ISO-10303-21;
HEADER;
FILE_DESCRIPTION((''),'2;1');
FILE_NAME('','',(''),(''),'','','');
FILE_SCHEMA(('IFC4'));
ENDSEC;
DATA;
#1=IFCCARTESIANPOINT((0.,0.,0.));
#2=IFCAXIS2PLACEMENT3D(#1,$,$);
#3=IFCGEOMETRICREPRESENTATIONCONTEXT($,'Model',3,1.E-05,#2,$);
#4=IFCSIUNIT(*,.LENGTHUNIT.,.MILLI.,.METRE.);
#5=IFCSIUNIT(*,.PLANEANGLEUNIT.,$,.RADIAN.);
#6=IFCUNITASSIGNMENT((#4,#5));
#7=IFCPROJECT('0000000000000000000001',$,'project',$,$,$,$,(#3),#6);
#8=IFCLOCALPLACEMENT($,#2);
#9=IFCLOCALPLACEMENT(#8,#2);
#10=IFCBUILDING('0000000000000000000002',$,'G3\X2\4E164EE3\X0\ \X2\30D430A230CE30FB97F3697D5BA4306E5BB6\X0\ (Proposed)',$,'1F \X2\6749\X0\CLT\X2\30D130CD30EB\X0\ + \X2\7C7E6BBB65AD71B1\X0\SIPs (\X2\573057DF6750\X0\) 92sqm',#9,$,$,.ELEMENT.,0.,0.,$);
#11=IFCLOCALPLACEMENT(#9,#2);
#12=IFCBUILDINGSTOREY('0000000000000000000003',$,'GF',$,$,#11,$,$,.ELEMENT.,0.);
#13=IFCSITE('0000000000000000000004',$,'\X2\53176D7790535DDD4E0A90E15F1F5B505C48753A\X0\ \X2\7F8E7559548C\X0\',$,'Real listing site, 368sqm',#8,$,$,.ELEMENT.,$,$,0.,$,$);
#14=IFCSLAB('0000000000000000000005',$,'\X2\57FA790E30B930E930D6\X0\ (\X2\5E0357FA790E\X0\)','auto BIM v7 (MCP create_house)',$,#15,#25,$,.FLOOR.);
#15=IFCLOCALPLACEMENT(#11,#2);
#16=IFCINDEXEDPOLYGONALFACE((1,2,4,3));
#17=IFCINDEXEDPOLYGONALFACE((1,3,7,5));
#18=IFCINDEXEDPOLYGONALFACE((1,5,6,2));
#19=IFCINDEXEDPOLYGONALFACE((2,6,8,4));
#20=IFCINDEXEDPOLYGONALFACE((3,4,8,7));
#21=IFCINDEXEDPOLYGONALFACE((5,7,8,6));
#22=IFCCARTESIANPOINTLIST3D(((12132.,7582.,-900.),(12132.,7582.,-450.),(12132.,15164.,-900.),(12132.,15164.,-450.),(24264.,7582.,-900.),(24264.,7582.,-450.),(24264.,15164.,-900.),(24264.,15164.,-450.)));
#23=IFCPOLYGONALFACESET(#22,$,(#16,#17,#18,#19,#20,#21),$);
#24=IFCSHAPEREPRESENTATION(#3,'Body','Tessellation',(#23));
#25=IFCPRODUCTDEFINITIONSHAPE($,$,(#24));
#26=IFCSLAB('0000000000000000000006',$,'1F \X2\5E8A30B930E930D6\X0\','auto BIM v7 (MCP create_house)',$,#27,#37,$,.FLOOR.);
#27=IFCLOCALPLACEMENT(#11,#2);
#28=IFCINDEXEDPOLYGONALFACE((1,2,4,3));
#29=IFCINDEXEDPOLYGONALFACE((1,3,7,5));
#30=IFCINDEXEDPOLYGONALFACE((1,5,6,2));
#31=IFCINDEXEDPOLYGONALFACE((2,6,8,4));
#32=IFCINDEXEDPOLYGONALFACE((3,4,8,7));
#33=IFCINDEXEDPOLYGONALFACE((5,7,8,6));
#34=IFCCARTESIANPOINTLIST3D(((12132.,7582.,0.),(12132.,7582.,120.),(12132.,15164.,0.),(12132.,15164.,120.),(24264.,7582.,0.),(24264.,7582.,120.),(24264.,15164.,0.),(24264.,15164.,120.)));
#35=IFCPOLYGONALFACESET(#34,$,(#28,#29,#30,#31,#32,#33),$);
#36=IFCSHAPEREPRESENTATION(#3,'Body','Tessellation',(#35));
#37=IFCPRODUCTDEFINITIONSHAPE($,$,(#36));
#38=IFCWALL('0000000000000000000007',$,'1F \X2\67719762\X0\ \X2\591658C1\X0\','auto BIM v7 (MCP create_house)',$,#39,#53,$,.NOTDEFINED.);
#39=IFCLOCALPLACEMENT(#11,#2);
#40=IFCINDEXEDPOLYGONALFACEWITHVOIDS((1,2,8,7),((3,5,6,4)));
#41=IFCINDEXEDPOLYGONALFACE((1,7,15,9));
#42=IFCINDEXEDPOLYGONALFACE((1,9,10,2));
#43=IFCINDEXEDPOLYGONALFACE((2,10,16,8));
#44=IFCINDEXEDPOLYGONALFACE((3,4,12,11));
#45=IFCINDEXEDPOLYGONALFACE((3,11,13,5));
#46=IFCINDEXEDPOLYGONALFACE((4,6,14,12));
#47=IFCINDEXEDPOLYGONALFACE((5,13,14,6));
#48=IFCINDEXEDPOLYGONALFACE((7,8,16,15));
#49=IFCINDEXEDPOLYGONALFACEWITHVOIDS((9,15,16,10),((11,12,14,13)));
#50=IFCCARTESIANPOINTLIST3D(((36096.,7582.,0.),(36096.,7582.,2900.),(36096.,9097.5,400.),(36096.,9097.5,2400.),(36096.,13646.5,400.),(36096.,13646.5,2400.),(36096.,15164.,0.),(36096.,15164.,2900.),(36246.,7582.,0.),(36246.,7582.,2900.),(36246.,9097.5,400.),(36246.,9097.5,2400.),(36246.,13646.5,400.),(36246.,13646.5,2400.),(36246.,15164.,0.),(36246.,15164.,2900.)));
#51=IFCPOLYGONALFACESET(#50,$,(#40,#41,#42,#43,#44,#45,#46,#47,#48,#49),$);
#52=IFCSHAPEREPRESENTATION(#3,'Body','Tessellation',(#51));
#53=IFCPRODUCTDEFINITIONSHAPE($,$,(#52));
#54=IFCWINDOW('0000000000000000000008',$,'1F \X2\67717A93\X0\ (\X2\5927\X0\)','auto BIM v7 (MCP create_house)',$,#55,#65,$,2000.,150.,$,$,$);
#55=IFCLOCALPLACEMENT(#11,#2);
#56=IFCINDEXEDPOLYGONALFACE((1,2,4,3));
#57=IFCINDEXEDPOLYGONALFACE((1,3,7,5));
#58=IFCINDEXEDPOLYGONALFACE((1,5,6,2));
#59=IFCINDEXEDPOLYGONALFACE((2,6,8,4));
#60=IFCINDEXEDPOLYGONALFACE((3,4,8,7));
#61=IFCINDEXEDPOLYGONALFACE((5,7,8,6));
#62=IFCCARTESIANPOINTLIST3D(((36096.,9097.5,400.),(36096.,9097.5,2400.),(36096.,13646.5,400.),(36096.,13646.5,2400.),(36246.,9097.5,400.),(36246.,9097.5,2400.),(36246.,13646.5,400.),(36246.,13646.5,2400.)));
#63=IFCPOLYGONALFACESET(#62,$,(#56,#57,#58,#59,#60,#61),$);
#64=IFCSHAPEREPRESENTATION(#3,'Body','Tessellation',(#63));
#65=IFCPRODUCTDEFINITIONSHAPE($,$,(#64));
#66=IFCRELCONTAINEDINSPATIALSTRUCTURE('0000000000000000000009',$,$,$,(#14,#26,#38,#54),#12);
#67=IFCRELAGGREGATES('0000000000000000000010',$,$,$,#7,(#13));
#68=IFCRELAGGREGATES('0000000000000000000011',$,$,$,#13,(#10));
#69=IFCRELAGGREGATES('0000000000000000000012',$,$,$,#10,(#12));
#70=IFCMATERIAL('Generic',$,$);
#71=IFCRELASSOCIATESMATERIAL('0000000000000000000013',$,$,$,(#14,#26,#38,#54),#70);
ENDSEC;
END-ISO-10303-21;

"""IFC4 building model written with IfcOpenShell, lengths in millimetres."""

from ifc_helpers import new_model, si_unit, frame, frame_2d, origin, place, context, project, spatial, rectangle, extrude, material, element, fill, save


model = new_model("IFC4")

# Units and contexts
model_context = context("Model", 3, precision=1e-05, world=origin())
ifc_project = project(units=[si_unit("LENGTHUNIT", "METRE", prefix="MILLI"), si_unit("PLANEANGLEUNIT", "RADIAN")], contexts=[model_context])

# Site, building, storey
site_placement = place(None, origin())
site = spatial("IfcSite", under=ifc_project, at=site_placement, Name="北海道川上郡弟子屈町 美留和", ObjectType="Real listing site, 368sqm", CompositionType="ELEMENT", RefElevation=0.0)
building_placement = place(site_placement, origin())
building = spatial("IfcBuilding", under=site, at=building_placement, Name="G3世代 ピアノ・音楽室の家 (Proposed)", ObjectType="1F 杉CLTパネル + 籾殻断熱SIPs (地域材) 92sqm", CompositionType="ELEMENT", ElevationOfRefHeight=0.0, ElevationOfTerrain=0.0)
storey_placement = place(building_placement, origin())
storey = spatial("IfcBuildingStorey", under=building, at=storey_placement, Name="GF", CompositionType="ELEMENT", Elevation=0.0)

# Slabs
ifc_material = material(Name="Generic")
slab_1_placement = place(storey_placement, frame((6066.0, 3791.0, -450.0)))
element("IfcSlab", 1, at=slab_1_placement, inside=storey, material=ifc_material, Name="基礎スラブ (布基礎)", Description="auto BIM v7 (MCP create_house)", PredefinedType="FLOOR", context=model_context, shape_type="SweptSolid", body=[
    extrude(rectangle(XDim=12132.0, YDim=7582.0, at=frame_2d((6066.0, 3791.0))), frame((6066.0, 3791.0, -450.0)), (0.0, 0.0, 1.0), 450.0),
])
slab_2_placement = place(storey_placement, frame((6066.0, 3791.0, 0.0)))
element("IfcSlab", 2, at=slab_2_placement, inside=storey, material=ifc_material, Name="1F 床スラブ", Description="auto BIM v7 (MCP create_house)", PredefinedType="FLOOR", context=model_context, shape_type="SweptSolid", body=[
    extrude(rectangle(XDim=12132.0, YDim=7582.0, at=frame_2d((6066.0, 3791.0))), frame((6066.0, 3791.0, 0.0)), (0.0, 0.0, 1.0), 120.0),
])

# Wall, opening, window
wall_1_placement = place(storey_placement, frame((18048.0, 3791.0, 0.0)))
wall_1 = element("IfcWall", 3, at=wall_1_placement, inside=storey, material=ifc_material, Name="1F 東面 外壁", Description="auto BIM v7 (MCP create_house)", PredefinedType="NOTDEFINED", context=model_context, shape_type="SweptSolid", body=[
    extrude(rectangle(XDim=150.0, YDim=7582.0, at=frame_2d((75.0, 3791.0))), frame((18048.0, 3791.0, 0.0)), (0.0, 0.0, 1.0), 2900.0),
])
opening_1_placement = place(storey_placement, frame((18048.0, 4549.0, 200.0)))
opening_1 = element("IfcOpeningElement", 4, at=opening_1_placement, cuts=wall_1, PredefinedType="NOTDEFINED", context=model_context, shape_type="SweptSolid", body=[
    extrude(rectangle(XDim=150.0, YDim=4549.0, at=frame_2d((75.0, 2274.0))), frame((18048.0, 4549.0, 200.0)), (0.0, 0.0, 1.0), 2000.0),
])
window_1_placement = place(storey_placement, frame((18048.0, 4549.0, 200.0)))
window_1 = element("IfcWindow", 5, at=window_1_placement, inside=storey, material=ifc_material, Name="1F 東窓 (大)", Description="auto BIM v7 (MCP create_house)", OverallHeight=2000.0, OverallWidth=150.0, context=model_context, shape_type="SweptSolid", body=[
    extrude(rectangle(XDim=150.0, YDim=4549.0, at=frame_2d((75.0, 2274.0))), frame((18048.0, 4549.0, 200.0)), (0.0, 0.0, 1.0), 2000.0),
])
fill(opening_1, window_1)

save(model, "model.ifc")
